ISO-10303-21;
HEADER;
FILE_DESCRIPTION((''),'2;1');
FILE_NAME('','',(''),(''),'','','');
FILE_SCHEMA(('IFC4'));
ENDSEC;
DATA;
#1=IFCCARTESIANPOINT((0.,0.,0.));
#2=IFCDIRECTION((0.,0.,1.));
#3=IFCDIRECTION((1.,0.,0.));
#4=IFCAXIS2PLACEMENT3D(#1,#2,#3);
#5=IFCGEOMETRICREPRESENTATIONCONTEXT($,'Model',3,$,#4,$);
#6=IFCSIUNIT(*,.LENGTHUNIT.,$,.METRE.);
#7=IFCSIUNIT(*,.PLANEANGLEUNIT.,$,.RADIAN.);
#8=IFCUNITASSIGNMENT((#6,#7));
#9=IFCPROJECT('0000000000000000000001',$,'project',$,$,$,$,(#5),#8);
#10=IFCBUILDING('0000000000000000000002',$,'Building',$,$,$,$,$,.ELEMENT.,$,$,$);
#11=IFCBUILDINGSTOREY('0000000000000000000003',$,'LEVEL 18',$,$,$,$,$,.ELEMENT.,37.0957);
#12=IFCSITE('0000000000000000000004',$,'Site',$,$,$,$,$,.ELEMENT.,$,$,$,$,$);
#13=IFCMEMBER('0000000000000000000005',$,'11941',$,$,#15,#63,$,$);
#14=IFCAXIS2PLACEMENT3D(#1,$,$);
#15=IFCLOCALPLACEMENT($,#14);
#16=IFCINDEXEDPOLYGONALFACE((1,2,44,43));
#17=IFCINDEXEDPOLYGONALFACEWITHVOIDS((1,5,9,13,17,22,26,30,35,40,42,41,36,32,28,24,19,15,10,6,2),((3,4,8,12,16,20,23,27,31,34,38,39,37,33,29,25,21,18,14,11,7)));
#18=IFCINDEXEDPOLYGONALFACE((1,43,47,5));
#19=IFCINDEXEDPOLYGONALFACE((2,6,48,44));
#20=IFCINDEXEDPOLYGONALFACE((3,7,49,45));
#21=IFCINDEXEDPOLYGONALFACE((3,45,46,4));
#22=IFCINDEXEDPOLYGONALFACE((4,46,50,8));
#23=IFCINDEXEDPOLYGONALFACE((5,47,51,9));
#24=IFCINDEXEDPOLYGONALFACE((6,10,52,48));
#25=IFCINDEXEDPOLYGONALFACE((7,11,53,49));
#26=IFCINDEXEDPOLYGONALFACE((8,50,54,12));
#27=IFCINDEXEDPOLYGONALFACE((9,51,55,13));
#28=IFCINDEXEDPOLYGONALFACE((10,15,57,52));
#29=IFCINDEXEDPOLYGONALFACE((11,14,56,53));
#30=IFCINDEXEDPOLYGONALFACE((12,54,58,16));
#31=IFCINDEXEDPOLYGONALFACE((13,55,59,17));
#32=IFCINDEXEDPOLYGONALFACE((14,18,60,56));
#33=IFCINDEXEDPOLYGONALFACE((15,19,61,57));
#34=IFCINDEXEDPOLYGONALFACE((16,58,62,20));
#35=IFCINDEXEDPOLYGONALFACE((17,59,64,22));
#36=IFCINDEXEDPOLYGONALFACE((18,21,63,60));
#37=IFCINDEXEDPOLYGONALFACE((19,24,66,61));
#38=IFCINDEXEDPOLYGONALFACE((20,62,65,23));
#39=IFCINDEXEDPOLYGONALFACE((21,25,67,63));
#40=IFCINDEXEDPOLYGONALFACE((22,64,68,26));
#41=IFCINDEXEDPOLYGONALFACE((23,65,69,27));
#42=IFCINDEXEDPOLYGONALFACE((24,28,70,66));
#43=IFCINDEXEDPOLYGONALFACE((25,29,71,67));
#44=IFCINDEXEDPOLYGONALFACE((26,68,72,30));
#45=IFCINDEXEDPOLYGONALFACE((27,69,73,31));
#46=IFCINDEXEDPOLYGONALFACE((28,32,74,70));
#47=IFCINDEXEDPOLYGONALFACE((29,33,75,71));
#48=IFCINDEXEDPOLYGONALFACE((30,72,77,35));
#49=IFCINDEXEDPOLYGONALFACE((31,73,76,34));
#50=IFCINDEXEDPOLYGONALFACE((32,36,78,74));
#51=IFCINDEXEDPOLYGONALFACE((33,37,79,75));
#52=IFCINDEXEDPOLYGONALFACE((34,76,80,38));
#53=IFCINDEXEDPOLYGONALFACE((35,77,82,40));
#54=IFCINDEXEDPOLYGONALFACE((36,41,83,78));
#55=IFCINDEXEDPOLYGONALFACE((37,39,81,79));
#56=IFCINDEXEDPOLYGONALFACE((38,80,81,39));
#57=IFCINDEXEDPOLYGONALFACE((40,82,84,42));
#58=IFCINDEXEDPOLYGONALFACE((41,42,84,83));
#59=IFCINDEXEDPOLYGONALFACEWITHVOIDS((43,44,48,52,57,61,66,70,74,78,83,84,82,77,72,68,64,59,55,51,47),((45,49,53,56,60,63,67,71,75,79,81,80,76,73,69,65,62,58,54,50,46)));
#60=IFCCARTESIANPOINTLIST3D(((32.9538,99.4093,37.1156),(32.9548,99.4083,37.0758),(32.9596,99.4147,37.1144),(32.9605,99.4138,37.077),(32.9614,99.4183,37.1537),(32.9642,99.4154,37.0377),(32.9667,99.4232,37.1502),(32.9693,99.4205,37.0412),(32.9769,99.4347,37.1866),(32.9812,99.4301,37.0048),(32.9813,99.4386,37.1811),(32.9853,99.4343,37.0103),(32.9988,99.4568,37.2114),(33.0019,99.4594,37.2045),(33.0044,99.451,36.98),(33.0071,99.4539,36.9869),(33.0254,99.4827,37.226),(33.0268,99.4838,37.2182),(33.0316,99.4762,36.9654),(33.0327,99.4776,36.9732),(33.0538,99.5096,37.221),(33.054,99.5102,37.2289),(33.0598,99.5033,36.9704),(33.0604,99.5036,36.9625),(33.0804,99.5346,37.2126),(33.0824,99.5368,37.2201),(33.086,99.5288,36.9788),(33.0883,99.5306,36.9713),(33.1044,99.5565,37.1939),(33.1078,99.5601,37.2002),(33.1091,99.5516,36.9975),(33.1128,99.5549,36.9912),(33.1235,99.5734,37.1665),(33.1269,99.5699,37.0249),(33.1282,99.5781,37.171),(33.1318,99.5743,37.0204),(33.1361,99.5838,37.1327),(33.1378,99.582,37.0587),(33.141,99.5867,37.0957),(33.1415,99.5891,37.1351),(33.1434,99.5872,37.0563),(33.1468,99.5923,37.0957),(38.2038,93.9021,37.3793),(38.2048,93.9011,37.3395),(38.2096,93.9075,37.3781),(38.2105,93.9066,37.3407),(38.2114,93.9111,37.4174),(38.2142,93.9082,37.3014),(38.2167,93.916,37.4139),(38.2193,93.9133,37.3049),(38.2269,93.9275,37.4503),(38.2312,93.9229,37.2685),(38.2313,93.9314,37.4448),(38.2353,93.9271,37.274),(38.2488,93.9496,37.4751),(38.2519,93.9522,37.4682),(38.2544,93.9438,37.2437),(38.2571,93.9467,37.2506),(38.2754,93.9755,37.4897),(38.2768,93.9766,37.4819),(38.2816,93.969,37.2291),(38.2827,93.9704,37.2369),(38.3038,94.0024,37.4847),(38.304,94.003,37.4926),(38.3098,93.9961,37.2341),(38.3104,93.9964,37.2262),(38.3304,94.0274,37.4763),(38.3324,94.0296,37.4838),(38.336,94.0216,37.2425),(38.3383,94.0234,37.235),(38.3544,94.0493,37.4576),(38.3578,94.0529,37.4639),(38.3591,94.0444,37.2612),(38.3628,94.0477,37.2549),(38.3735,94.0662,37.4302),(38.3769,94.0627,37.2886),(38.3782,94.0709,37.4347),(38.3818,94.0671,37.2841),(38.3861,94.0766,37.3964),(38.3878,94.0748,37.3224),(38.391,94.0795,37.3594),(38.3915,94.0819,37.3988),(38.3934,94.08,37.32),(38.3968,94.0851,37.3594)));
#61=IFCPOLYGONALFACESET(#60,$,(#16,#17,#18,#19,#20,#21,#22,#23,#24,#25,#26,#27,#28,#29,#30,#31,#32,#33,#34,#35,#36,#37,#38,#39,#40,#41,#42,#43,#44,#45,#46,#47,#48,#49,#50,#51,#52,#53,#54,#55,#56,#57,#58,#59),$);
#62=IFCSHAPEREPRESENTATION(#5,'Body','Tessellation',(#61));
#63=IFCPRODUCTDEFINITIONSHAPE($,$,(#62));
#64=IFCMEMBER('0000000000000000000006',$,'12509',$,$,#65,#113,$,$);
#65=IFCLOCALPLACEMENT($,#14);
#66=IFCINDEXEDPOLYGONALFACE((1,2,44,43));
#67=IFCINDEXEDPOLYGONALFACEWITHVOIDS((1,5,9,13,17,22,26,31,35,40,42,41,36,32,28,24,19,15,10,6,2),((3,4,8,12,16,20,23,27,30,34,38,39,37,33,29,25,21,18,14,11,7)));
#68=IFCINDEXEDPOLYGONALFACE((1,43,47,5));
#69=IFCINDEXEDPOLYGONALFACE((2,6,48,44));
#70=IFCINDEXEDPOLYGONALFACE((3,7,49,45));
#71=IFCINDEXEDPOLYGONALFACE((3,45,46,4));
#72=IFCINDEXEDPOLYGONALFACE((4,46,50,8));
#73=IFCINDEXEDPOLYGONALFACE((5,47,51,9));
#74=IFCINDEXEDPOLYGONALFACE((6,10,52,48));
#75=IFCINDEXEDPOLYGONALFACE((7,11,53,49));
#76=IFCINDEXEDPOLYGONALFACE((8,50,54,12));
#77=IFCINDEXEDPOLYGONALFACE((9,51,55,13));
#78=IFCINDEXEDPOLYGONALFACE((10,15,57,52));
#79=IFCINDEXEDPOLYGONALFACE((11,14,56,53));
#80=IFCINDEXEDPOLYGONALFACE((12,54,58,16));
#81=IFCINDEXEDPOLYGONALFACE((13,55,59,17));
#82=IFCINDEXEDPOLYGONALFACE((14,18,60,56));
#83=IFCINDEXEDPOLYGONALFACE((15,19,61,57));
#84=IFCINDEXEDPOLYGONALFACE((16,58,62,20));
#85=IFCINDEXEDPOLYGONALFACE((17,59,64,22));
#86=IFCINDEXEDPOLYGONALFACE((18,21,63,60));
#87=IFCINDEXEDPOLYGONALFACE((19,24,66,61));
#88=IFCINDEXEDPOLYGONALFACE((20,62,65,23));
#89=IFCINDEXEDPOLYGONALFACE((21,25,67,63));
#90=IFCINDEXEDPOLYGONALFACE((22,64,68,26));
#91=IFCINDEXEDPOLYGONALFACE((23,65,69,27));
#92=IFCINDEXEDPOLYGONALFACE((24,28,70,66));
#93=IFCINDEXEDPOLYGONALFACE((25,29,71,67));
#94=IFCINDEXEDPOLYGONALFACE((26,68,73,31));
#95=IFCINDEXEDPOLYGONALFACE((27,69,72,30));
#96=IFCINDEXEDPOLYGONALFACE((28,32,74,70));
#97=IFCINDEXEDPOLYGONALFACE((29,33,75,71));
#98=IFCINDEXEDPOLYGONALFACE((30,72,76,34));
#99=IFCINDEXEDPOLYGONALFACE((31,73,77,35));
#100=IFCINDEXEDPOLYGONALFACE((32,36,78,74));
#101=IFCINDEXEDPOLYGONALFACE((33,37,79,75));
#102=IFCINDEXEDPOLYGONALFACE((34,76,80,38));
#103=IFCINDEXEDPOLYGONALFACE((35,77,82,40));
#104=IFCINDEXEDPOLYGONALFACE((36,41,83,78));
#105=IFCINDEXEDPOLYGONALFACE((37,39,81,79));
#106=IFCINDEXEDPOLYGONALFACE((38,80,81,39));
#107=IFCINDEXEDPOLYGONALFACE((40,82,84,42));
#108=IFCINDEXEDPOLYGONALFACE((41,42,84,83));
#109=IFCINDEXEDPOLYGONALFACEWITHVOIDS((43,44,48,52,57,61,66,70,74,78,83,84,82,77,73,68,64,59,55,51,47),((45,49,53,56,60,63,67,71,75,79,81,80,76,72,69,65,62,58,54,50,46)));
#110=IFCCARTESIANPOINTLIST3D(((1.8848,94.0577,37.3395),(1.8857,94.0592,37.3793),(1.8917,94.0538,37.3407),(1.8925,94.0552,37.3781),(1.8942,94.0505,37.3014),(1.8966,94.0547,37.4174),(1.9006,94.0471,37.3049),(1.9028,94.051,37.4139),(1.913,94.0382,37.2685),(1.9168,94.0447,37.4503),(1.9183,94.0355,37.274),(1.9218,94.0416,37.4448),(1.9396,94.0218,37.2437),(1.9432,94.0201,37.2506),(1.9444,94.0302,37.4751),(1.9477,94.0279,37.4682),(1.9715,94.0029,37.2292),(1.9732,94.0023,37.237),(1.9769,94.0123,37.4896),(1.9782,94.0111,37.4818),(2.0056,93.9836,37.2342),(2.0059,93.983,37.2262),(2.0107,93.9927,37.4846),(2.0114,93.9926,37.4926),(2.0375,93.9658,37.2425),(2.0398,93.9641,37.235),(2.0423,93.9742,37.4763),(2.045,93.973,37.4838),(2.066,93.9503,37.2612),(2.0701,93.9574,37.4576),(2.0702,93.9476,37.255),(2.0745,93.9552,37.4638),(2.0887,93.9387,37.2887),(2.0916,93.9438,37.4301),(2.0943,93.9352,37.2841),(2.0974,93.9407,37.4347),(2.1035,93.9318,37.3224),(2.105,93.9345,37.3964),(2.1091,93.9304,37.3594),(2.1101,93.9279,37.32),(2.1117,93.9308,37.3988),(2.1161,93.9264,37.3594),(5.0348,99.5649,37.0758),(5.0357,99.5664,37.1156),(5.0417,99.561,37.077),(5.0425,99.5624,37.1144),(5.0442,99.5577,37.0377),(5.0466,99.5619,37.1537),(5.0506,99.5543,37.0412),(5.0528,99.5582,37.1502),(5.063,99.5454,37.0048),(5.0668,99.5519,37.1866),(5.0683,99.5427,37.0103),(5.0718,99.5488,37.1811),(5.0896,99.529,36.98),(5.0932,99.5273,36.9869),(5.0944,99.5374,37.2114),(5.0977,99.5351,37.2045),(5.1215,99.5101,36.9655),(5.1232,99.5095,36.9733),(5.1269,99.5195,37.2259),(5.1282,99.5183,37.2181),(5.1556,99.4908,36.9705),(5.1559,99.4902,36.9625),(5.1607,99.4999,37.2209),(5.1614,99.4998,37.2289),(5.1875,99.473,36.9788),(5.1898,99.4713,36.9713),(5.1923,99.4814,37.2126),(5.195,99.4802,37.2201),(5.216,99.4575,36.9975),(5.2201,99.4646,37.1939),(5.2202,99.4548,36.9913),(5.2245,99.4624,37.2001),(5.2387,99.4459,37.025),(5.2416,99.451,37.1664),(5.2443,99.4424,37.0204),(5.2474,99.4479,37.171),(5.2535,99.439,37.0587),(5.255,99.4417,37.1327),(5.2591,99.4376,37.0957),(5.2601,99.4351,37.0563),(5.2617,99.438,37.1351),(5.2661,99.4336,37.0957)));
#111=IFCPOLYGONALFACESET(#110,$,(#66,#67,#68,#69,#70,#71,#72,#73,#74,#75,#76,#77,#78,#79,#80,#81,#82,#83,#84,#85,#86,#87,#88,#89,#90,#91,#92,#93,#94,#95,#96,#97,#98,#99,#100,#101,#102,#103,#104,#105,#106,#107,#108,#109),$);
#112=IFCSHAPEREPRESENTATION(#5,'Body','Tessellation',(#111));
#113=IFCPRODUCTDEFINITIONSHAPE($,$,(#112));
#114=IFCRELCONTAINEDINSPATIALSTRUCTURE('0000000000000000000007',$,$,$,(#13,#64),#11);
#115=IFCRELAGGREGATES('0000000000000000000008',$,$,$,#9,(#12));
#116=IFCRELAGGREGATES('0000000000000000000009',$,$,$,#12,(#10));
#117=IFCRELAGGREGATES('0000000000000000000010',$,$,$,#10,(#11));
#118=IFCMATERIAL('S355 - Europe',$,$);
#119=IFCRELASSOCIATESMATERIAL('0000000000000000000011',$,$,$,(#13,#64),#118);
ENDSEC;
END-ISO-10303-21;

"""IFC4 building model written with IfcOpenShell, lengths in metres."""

from ifc_helpers import new_model, si_unit, frame, origin_with_axes, origin_2d_with_axis, place, context, project, spatial, hollow_circle, extrude, material, material_profile, profile_set, profile_usage, element, save


model = new_model("IFC4")

# Units and contexts
model_context = context("Model", 3, world=origin_with_axes())
ifc_project = project(units=[si_unit("LENGTHUNIT", "METRE"), si_unit("PLANEANGLEUNIT", "RADIAN")], contexts=[model_context])

# Site, building, storey
site = spatial("IfcSite", under=ifc_project, Name="Site", CompositionType="ELEMENT")
building = spatial("IfcBuilding", under=site, Name="Building", CompositionType="ELEMENT")
storey = spatial("IfcBuildingStorey", under=building, Name="LEVEL 18", CompositionType="ELEMENT", Elevation=37.0957)

# Shared definitions
ifc_material = material(Name="S355 - Europe")

# Members
ifc_material_profile_1 = material_profile(ifc_material, hollow_circle(Radius=0.1337, WallThickness=0.008, at=origin_2d_with_axis()))
ifc_profile_set_1 = profile_set([ifc_material_profile_1])
ifc_profile_usage_1 = profile_usage(ifc_profile_set_1, cardinal=10)
member_1_placement = place(None, frame((33.05, 99.5, 37.0957), z_axis=(0.689589, -0.723372, 0.034637), x_axis=(0.723807, 0.690003, 0.0)))
element("IfcMember", 1, at=member_1_placement, inside=storey, material=ifc_profile_usage_1, Name="11941", context=model_context, shape_type="SweptSolid", body=[
    extrude(hollow_circle(Radius=0.1337, WallThickness=0.008, at=origin_2d_with_axis()), origin_with_axes(), (0.0, 0.0, 1.0), 7.6132),
])
ifc_material_profile_2 = material_profile(ifc_material, hollow_circle(Radius=0.1337, WallThickness=0.008, at=origin_2d_with_axis()))
ifc_profile_set_2 = profile_set([ifc_material_profile_2])
ifc_profile_usage_2 = profile_usage(ifc_profile_set_2, cardinal=10)
member_2_placement = place(None, frame((5.15, 99.5, 37.0957), z_axis=(-0.49607, -0.867289, 0.041528), x_axis=(0.868037, -0.496499, 0.0)))
element("IfcMember", 2, at=member_2_placement, inside=storey, material=ifc_profile_usage_2, Name="12509", context=model_context, shape_type="SweptSolid", body=[
    extrude(hollow_circle(Radius=0.1337, WallThickness=0.008, at=origin_2d_with_axis()), origin_with_axes(), (0.0, 0.0, 1.0), 6.3499),
])

save(model, "model.ifc")
